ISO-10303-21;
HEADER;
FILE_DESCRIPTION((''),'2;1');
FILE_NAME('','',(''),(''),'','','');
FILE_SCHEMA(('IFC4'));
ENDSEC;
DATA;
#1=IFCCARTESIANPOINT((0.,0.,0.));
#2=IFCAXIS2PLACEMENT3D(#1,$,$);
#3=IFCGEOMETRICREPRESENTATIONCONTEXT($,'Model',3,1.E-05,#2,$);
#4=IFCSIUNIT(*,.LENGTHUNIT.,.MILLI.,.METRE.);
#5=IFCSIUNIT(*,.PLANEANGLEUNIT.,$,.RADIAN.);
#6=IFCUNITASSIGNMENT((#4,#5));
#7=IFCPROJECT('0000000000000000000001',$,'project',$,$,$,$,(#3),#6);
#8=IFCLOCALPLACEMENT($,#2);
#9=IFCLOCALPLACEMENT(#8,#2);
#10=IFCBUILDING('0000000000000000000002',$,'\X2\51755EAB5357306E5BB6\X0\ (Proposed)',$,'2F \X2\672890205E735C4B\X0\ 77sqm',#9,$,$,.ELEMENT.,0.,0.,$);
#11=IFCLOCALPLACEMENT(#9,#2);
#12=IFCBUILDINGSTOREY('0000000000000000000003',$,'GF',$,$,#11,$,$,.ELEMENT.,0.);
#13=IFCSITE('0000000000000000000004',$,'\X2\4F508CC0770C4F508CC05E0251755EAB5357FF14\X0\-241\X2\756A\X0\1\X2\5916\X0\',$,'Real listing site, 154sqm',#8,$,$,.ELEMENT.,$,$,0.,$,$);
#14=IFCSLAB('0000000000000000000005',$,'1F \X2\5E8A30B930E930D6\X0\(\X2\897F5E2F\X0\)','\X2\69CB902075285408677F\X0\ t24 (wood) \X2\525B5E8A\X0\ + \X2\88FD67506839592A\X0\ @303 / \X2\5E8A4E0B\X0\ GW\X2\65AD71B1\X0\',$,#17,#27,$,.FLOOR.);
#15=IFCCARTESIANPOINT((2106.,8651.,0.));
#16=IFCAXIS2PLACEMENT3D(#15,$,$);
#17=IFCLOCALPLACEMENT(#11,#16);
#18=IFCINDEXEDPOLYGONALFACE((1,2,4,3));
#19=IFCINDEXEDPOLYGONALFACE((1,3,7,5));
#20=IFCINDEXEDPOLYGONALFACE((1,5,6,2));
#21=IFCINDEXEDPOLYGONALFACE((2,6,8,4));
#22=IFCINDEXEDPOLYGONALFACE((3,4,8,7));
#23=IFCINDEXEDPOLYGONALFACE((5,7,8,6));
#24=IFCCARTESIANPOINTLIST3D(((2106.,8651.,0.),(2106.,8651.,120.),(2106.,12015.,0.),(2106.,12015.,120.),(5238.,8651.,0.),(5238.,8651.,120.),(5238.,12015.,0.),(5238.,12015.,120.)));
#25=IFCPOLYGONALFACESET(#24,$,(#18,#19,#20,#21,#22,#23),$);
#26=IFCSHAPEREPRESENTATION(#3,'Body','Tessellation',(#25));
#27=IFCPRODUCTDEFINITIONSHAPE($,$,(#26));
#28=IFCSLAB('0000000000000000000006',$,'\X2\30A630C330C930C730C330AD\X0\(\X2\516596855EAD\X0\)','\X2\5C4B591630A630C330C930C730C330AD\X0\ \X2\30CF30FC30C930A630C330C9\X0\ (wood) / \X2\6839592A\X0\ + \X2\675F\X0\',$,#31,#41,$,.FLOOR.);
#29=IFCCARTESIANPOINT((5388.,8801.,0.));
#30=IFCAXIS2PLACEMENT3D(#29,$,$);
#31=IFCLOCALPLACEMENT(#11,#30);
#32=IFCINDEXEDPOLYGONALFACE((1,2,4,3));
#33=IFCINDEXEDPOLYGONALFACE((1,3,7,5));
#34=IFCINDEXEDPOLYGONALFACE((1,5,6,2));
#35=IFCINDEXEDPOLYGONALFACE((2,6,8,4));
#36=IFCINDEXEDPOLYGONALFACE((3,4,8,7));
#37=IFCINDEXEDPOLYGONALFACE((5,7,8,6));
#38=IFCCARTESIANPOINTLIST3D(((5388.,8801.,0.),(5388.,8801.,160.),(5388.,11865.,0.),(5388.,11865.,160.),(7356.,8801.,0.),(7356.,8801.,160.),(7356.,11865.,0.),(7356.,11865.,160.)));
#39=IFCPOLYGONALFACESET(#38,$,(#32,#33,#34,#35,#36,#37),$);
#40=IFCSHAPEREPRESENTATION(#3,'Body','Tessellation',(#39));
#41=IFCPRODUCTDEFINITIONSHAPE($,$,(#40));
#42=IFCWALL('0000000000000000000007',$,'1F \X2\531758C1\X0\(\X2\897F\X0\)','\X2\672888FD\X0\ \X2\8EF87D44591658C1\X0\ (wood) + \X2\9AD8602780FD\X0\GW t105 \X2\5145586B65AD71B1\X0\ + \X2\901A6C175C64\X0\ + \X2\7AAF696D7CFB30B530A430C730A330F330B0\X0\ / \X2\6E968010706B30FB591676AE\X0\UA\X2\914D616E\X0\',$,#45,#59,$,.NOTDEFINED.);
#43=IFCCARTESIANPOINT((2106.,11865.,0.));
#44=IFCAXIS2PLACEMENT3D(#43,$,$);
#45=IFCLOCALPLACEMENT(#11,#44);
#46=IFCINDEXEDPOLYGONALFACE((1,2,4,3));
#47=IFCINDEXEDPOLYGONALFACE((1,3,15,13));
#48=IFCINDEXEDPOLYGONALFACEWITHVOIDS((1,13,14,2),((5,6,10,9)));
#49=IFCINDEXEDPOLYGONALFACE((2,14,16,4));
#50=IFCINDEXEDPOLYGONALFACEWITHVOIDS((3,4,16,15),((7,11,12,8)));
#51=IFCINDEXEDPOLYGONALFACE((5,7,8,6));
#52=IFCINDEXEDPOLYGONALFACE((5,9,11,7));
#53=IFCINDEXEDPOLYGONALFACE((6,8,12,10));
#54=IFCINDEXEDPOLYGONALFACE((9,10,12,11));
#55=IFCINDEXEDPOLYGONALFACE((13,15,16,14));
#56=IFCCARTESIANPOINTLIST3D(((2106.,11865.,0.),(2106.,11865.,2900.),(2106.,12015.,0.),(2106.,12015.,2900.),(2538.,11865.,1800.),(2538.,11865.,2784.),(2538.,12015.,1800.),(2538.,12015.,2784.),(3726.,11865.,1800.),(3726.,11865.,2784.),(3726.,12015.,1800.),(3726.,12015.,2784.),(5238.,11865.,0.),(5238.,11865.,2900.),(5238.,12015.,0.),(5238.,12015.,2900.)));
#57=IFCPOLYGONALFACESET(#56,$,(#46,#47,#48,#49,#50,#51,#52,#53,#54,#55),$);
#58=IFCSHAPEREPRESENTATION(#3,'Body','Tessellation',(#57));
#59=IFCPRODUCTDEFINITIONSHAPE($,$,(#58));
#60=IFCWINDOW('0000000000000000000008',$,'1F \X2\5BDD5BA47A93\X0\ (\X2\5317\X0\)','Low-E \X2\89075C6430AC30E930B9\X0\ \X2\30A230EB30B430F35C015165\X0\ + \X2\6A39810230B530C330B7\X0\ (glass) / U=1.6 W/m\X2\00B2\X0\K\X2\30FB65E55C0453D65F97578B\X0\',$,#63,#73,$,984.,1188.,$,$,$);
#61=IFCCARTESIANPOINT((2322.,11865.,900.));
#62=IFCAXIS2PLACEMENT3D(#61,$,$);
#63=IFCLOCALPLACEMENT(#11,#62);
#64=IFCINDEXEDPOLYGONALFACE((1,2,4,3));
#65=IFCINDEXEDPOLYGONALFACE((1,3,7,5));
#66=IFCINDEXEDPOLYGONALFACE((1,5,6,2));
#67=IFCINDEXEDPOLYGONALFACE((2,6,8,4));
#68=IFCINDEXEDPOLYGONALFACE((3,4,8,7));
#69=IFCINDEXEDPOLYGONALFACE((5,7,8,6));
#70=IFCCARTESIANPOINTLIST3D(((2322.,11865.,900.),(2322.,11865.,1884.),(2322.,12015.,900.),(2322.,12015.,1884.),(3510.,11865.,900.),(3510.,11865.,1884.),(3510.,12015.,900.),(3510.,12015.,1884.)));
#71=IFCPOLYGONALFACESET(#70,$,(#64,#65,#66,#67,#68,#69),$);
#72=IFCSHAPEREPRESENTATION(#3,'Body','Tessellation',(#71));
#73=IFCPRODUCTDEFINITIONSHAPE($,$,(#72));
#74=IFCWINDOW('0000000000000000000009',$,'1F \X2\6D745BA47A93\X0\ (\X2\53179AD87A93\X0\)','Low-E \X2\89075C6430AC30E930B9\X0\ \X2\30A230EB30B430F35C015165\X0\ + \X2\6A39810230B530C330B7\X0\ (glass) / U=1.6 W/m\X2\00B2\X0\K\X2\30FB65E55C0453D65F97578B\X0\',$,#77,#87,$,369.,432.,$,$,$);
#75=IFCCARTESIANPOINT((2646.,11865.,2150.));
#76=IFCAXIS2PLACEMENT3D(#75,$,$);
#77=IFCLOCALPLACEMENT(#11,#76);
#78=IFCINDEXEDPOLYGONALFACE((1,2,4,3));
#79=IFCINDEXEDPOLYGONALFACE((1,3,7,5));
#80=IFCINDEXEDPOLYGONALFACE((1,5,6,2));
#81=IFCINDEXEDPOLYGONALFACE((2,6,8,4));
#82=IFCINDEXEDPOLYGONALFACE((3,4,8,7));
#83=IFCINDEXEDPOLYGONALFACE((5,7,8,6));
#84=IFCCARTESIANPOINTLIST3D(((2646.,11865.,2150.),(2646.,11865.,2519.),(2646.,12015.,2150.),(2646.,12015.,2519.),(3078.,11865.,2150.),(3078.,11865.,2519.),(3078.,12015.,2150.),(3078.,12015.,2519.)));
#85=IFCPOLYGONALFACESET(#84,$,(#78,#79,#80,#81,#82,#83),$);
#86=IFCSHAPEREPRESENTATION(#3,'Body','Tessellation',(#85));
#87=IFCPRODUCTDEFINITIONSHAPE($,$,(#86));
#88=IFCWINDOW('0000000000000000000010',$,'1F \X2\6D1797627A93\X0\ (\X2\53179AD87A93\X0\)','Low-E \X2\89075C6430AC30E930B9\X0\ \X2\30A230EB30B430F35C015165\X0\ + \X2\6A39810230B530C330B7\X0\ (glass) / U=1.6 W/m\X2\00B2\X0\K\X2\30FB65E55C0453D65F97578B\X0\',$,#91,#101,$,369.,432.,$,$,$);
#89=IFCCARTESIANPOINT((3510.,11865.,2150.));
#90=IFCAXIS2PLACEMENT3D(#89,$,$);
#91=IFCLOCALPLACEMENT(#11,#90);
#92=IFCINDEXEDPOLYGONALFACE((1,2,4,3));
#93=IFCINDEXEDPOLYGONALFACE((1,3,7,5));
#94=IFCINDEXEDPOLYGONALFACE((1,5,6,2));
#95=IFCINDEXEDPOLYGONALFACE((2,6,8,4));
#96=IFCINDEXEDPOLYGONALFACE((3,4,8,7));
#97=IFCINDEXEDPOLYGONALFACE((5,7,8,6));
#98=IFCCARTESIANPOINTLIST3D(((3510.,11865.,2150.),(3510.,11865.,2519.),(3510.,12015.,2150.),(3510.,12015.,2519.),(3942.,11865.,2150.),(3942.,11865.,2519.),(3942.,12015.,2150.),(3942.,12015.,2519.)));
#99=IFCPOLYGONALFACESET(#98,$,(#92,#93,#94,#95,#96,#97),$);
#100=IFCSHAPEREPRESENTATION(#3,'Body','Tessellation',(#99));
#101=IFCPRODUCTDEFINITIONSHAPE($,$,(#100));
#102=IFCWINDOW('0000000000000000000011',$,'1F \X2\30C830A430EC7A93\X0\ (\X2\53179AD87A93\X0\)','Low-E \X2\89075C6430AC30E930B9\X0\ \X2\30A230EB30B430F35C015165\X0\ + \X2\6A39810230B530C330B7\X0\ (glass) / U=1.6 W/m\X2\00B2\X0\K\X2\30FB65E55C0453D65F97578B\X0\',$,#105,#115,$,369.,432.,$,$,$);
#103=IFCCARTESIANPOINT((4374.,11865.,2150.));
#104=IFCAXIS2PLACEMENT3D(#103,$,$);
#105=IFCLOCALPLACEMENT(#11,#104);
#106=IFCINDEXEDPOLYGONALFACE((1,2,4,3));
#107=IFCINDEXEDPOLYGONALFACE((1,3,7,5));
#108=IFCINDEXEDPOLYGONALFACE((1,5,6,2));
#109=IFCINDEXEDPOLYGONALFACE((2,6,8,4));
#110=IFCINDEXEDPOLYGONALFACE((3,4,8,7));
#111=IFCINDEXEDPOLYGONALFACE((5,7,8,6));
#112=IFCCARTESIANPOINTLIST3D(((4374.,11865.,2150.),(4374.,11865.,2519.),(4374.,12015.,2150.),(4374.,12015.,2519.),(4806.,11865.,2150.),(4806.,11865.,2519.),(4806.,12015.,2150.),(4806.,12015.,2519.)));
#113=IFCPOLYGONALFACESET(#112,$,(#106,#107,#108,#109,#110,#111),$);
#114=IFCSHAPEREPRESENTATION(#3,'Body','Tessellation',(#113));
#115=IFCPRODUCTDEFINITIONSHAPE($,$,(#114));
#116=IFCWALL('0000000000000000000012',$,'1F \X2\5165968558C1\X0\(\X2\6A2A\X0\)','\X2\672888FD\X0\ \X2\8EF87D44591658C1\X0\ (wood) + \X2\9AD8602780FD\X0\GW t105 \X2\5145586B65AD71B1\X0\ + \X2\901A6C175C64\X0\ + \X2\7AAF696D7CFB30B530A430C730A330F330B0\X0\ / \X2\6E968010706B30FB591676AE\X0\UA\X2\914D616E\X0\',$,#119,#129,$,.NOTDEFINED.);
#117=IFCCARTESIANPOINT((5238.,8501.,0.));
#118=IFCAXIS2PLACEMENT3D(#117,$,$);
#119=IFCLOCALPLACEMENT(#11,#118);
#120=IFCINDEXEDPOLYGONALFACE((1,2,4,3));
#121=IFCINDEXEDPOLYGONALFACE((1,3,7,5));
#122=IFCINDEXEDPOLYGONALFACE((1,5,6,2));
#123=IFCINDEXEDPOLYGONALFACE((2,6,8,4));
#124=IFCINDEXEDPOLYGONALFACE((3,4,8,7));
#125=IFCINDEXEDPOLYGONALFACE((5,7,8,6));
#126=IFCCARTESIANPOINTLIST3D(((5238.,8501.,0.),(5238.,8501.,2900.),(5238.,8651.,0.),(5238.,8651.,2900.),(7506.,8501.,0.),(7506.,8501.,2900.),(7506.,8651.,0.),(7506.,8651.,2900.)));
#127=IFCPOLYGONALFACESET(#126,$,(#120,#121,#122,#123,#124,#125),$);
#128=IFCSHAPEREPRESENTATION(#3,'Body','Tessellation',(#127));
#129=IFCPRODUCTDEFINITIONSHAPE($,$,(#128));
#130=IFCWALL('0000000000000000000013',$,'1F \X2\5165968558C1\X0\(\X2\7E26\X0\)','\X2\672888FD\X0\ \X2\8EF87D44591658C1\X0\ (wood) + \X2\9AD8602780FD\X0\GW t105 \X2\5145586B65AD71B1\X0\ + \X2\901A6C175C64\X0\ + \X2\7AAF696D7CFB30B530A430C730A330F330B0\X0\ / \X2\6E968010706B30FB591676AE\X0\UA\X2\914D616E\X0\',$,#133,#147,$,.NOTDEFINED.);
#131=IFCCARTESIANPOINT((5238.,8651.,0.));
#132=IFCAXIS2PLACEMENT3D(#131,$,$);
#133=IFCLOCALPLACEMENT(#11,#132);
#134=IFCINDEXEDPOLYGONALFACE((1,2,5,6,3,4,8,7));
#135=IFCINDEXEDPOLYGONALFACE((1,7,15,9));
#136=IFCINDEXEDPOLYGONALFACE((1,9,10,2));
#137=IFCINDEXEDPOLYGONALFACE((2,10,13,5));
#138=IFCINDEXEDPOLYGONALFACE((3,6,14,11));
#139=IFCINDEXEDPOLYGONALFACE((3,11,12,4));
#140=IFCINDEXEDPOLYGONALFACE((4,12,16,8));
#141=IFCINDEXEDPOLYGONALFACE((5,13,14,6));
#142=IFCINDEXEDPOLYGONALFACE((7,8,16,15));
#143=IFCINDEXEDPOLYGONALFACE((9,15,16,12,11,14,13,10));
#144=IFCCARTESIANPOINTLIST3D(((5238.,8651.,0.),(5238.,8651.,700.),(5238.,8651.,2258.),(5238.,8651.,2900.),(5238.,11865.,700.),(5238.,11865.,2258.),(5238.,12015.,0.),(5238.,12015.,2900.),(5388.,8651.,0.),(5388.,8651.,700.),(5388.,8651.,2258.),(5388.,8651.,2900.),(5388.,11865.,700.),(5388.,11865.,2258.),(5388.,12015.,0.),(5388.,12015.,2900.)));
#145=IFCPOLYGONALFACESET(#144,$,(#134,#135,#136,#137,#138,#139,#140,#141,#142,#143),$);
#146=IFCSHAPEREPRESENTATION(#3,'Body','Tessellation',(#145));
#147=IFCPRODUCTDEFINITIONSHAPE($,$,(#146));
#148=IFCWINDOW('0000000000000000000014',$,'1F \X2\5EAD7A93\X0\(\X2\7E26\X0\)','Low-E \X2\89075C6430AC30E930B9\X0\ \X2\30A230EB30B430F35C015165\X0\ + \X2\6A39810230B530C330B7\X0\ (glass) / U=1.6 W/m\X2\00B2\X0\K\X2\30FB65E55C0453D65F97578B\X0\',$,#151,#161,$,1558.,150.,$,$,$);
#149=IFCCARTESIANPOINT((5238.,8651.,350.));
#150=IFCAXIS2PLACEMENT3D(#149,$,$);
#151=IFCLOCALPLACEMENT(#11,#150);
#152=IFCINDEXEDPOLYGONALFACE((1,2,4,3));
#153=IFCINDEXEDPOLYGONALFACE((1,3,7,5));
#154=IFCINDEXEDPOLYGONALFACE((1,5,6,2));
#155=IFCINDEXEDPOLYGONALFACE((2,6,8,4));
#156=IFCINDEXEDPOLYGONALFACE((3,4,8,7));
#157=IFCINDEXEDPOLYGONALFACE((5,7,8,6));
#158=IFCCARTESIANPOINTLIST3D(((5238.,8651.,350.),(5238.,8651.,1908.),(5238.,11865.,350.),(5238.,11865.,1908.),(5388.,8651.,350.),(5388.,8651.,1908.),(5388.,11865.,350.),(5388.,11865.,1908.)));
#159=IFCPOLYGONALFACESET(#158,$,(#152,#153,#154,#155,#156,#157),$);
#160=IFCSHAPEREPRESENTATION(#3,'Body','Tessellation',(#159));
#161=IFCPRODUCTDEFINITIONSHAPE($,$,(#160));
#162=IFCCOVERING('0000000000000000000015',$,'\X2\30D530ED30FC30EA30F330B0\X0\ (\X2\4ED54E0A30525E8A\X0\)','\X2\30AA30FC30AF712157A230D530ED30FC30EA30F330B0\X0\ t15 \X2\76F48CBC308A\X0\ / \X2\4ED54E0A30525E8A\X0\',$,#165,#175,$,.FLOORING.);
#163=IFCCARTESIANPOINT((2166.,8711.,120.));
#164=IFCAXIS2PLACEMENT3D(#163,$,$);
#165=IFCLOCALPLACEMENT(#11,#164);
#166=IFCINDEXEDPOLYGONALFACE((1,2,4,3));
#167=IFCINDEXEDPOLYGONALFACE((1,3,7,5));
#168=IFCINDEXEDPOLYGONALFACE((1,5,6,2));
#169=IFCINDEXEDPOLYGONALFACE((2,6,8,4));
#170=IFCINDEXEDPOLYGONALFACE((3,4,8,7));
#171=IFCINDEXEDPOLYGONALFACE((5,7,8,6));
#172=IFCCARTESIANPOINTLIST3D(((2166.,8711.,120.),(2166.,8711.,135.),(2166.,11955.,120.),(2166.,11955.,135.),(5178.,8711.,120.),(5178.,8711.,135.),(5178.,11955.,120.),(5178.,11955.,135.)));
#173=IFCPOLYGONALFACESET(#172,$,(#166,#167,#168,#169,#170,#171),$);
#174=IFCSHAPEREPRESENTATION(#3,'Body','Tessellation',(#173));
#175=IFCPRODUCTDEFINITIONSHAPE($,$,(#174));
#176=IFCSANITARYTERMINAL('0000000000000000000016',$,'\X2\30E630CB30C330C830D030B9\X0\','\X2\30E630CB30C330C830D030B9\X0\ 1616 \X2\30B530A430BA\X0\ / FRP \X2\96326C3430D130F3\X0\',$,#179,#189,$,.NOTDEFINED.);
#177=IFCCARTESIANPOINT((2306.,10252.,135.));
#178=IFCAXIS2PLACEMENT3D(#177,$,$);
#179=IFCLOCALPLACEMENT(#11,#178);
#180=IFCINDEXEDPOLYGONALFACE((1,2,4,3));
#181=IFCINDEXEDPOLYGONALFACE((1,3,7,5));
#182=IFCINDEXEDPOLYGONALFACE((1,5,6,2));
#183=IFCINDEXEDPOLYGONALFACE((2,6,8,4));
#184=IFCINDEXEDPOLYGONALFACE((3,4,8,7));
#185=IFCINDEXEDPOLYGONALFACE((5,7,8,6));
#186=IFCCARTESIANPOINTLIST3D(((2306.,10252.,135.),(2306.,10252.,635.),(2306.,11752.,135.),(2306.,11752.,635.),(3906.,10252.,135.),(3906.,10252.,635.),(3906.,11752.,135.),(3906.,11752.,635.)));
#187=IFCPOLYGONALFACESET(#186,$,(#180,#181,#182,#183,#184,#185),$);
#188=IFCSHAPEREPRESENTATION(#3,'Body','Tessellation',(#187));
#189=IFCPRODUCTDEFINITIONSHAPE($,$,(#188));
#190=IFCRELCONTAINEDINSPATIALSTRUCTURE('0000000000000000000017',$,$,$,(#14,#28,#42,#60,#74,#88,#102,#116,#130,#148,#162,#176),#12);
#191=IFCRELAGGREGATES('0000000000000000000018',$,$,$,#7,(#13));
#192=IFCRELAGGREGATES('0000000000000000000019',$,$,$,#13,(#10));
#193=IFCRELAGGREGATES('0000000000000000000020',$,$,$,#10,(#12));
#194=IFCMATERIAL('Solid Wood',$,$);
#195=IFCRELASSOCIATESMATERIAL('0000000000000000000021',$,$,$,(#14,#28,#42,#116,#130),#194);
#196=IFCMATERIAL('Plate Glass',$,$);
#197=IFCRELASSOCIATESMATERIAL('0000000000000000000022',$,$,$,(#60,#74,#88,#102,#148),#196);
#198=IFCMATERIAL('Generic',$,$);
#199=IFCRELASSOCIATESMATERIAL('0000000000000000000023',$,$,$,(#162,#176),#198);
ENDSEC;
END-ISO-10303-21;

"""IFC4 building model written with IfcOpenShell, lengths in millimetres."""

from ifc_helpers import new_model, si_unit, frame, frame_2d, origin, place, context, project, spatial, rectangle, extrude, material, element, fill, save


model = new_model("IFC4")

# Units and contexts
model_context = context("Model", 3, precision=1e-05, world=origin())
ifc_project = project(units=[si_unit("LENGTHUNIT", "METRE", prefix="MILLI"), si_unit("PLANEANGLEUNIT", "RADIAN")], contexts=[model_context])

# Site, building, storey
site_placement = place(None, origin())
site = spatial("IfcSite", under=ifc_project, at=site_placement, Name="佐賀県佐賀市兵庫南４-241番1外", ObjectType="Real listing site, 154sqm", CompositionType="ELEMENT", RefElevation=0.0)
building_placement = place(site_placement, origin())
building = spatial("IfcBuilding", under=site, at=building_placement, Name="兵庫南の家 (Proposed)", ObjectType="2F 木造平屋 77sqm", CompositionType="ELEMENT", ElevationOfRefHeight=0.0, ElevationOfTerrain=0.0)
storey_placement = place(building_placement, origin())
storey = spatial("IfcBuildingStorey", under=building, at=storey_placement, Name="GF", CompositionType="ELEMENT", Elevation=0.0)

# Slabs
ifc_material_1 = material(Name="Solid Wood")
slab_1_placement = place(storey_placement, frame((2106.0, 8651.0, 0.0)))
element("IfcSlab", 1, at=slab_1_placement, inside=storey, material=ifc_material_1, Name="1F 床スラブ(西帯)", Description="構造用合板 t24 (wood) 剛床 + 製材根太 @303 / 床下 GW断熱", PredefinedType="FLOOR", context=model_context, shape_type="SweptSolid", body=[
    extrude(rectangle(XDim=3132.0, YDim=3364.0, at=frame_2d((1566.0, 1682.0))), frame((2106.0, 8651.0, 0.0)), (0.0, 0.0, 1.0), 120.0),
])
slab_2_placement = place(storey_placement, frame((5388.0, 8801.0, 0.0)))
element("IfcSlab", 2, at=slab_2_placement, inside=storey, material=ifc_material_1, Name="ウッドデッキ(入隅庭)", Description="屋外ウッドデッキ ハードウッド (wood) / 根太 + 束", PredefinedType="FLOOR", context=model_context, shape_type="SweptSolid", body=[
    extrude(rectangle(XDim=1968.0, YDim=3064.0, at=frame_2d((984.0, 1532.0))), frame((5388.0, 8801.0, 0.0)), (0.0, 0.0, 1.0), 160.0),
])

# Wall, openings, windows
wall_1_placement = place(storey_placement, frame((2106.0, 11865.0, 0.0)))
wall_1 = element("IfcWall", 3, at=wall_1_placement, inside=storey, material=ifc_material_1, Name="1F 北壁(西)", Description="木製 軸組外壁 (wood) + 高性能GW t105 充填断熱 + 通気層 + 窯業系サイディング / 準耐火・外皮UA配慮", PredefinedType="NOTDEFINED", context=model_context, shape_type="SweptSolid", body=[
    extrude(rectangle(XDim=3132.0, YDim=150.0, at=frame_2d((1566.0, 75.0))), frame((2106.0, 11865.0, 0.0)), (0.0, 0.0, 1.0), 2900.0),
])
opening_1_placement = place(storey_placement, frame((2322.0, 11865.0, 900.0)))
opening_1 = element("IfcOpeningElement", 4, at=opening_1_placement, cuts=wall_1, PredefinedType="NOTDEFINED", context=model_context, shape_type="SweptSolid", body=[
    extrude(rectangle(XDim=1188.0, YDim=150.0, at=frame_2d((594.0, 75.0))), frame((2322.0, 11865.0, 900.0)), (0.0, 0.0, 1.0), 984.0),
])
opening_2_placement = place(storey_placement, frame((2646.0, 11865.0, 2150.0)))
opening_2 = element("IfcOpeningElement", 5, at=opening_2_placement, cuts=wall_1, PredefinedType="NOTDEFINED", context=model_context, shape_type="SweptSolid", body=[
    extrude(rectangle(XDim=432.0, YDim=150.0, at=frame_2d((216.0, 75.0))), frame((2646.0, 11865.0, 2150.0)), (0.0, 0.0, 1.0), 369.0),
])
opening_3_placement = place(storey_placement, frame((3510.0, 11865.0, 2150.0)))
opening_3 = element("IfcOpeningElement", 6, at=opening_3_placement, cuts=wall_1, PredefinedType="NOTDEFINED", context=model_context, shape_type="SweptSolid", body=[
    extrude(rectangle(XDim=432.0, YDim=150.0, at=frame_2d((216.0, 75.0))), frame((3510.0, 11865.0, 2150.0)), (0.0, 0.0, 1.0), 369.0),
])
opening_4_placement = place(storey_placement, frame((4374.0, 11865.0, 2150.0)))
opening_4 = element("IfcOpeningElement", 7, at=opening_4_placement, cuts=wall_1, PredefinedType="NOTDEFINED", context=model_context, shape_type="SweptSolid", body=[
    extrude(rectangle(XDim=432.0, YDim=150.0, at=frame_2d((216.0, 75.0))), frame((4374.0, 11865.0, 2150.0)), (0.0, 0.0, 1.0), 369.0),
])
ifc_material_2 = material(Name="Plate Glass")
window_1_placement = place(storey_placement, frame((2322.0, 11865.0, 900.0)))
window_1 = element("IfcWindow", 8, at=window_1_placement, inside=storey, material=ifc_material_2, Name="1F 寝室窓 (北)", Description="Low-E 複層ガラス アルゴン封入 + 樹脂サッシ (glass) / U=1.6 W/m²K・日射取得型", OverallHeight=984.0, OverallWidth=1188.0, context=model_context, shape_type="SweptSolid", body=[
    extrude(rectangle(XDim=1188.0, YDim=150.0, at=frame_2d((594.0, 75.0))), frame((2322.0, 11865.0, 900.0)), (0.0, 0.0, 1.0), 984.0),
])
fill(opening_1, window_1)
window_2_placement = place(storey_placement, frame((2646.0, 11865.0, 2150.0)))
window_2 = element("IfcWindow", 9, at=window_2_placement, inside=storey, material=ifc_material_2, Name="1F 浴室窓 (北高窓)", Description="Low-E 複層ガラス アルゴン封入 + 樹脂サッシ (glass) / U=1.6 W/m²K・日射取得型", OverallHeight=369.0, OverallWidth=432.0, context=model_context, shape_type="SweptSolid", body=[
    extrude(rectangle(XDim=432.0, YDim=150.0, at=frame_2d((216.0, 75.0))), frame((2646.0, 11865.0, 2150.0)), (0.0, 0.0, 1.0), 369.0),
])
fill(opening_2, window_2)
window_3_placement = place(storey_placement, frame((3510.0, 11865.0, 2150.0)))
window_3 = element("IfcWindow", 10, at=window_3_placement, inside=storey, material=ifc_material_2, Name="1F 洗面窓 (北高窓)", Description="Low-E 複層ガラス アルゴン封入 + 樹脂サッシ (glass) / U=1.6 W/m²K・日射取得型", OverallHeight=369.0, OverallWidth=432.0, context=model_context, shape_type="SweptSolid", body=[
    extrude(rectangle(XDim=432.0, YDim=150.0, at=frame_2d((216.0, 75.0))), frame((3510.0, 11865.0, 2150.0)), (0.0, 0.0, 1.0), 369.0),
])
fill(opening_3, window_3)
window_4_placement = place(storey_placement, frame((4374.0, 11865.0, 2150.0)))
window_4 = element("IfcWindow", 11, at=window_4_placement, inside=storey, material=ifc_material_2, Name="1F トイレ窓 (北高窓)", Description="Low-E 複層ガラス アルゴン封入 + 樹脂サッシ (glass) / U=1.6 W/m²K・日射取得型", OverallHeight=369.0, OverallWidth=432.0, context=model_context, shape_type="SweptSolid", body=[
    extrude(rectangle(XDim=432.0, YDim=150.0, at=frame_2d((216.0, 75.0))), frame((4374.0, 11865.0, 2150.0)), (0.0, 0.0, 1.0), 369.0),
])
fill(opening_4, window_4)

# Wall
wall_2_placement = place(storey_placement, frame((5238.0, 8501.0, 0.0)))
element("IfcWall", 12, at=wall_2_placement, inside=storey, material=ifc_material_1, Name="1F 入隅壁(横)", Description="木製 軸組外壁 (wood) + 高性能GW t105 充填断熱 + 通気層 + 窯業系サイディング / 準耐火・外皮UA配慮", PredefinedType="NOTDEFINED", context=model_context, shape_type="SweptSolid", body=[
    extrude(rectangle(XDim=2268.0, YDim=150.0, at=frame_2d((1134.0, 75.0))), frame((5238.0, 8501.0, 0.0)), (0.0, 0.0, 1.0), 2900.0),
])

# Wall, opening, window
wall_3_placement = place(storey_placement, frame((5238.0, 8651.0, 0.0)))
wall_3 = element("IfcWall", 13, at=wall_3_placement, inside=storey, material=ifc_material_1, Name="1F 入隅壁(縦)", Description="木製 軸組外壁 (wood) + 高性能GW t105 充填断熱 + 通気層 + 窯業系サイディング / 準耐火・外皮UA配慮", PredefinedType="NOTDEFINED", context=model_context, shape_type="SweptSolid", body=[
    extrude(rectangle(XDim=150.0, YDim=3364.0, at=frame_2d((75.0, 1682.0))), frame((5238.0, 8651.0, 0.0)), (0.0, 0.0, 1.0), 2900.0),
])
opening_5_placement = place(storey_placement, frame((5238.0, 8651.0, 350.0)))
opening_5 = element("IfcOpeningElement", 14, at=opening_5_placement, cuts=wall_3, PredefinedType="NOTDEFINED", context=model_context, shape_type="SweptSolid", body=[
    extrude(rectangle(XDim=150.0, YDim=3214.0, at=frame_2d((75.0, 1607.0))), frame((5238.0, 8651.0, 350.0)), (0.0, 0.0, 1.0), 1558.0),
])
window_5_placement = place(storey_placement, frame((5238.0, 8651.0, 350.0)))
window_5 = element("IfcWindow", 15, at=window_5_placement, inside=storey, material=ifc_material_2, Name="1F 庭窓(縦)", Description="Low-E 複層ガラス アルゴン封入 + 樹脂サッシ (glass) / U=1.6 W/m²K・日射取得型", OverallHeight=1558.0, OverallWidth=150.0, context=model_context, shape_type="SweptSolid", body=[
    extrude(rectangle(XDim=150.0, YDim=3214.0, at=frame_2d((75.0, 1607.0))), frame((5238.0, 8651.0, 350.0)), (0.0, 0.0, 1.0), 1558.0),
])
fill(opening_5, window_5)

# Covering
ifc_material_3 = material(Name="Generic")
covering_placement = place(storey_placement, frame((2166.0, 8711.0, 120.0)))
element("IfcCovering", 16, at=covering_placement, inside=storey, material=ifc_material_3, Name="フローリング (仕上げ床)", Description="オーク無垢フローリング t15 直貼り / 仕上げ床", PredefinedType="FLOORING", context=model_context, shape_type="SweptSolid", body=[
    extrude(rectangle(XDim=3012.0, YDim=3244.0, at=frame_2d((1506.0, 1622.0))), frame((2166.0, 8711.0, 120.0)), (0.0, 0.0, 1.0), 15.0),
])

# Sanitary terminal
sanitary_terminal_1_placement = place(storey_placement, frame((2306.0, 10252.0, 135.0)))
element("IfcSanitaryTerminal", 17, at=sanitary_terminal_1_placement, inside=storey, material=ifc_material_3, Name="ユニットバス", Description="ユニットバス 1616 サイズ / FRP 防水パン", PredefinedType="NOTDEFINED", context=model_context, shape_type="SweptSolid", body=[
    extrude(rectangle(XDim=1600.0, YDim=1500.0, at=frame_2d((800.0, 750.0))), frame((2306.0, 10252.0, 135.0)), (0.0, 0.0, 1.0), 500.0),
])

save(model, "model.ifc")
